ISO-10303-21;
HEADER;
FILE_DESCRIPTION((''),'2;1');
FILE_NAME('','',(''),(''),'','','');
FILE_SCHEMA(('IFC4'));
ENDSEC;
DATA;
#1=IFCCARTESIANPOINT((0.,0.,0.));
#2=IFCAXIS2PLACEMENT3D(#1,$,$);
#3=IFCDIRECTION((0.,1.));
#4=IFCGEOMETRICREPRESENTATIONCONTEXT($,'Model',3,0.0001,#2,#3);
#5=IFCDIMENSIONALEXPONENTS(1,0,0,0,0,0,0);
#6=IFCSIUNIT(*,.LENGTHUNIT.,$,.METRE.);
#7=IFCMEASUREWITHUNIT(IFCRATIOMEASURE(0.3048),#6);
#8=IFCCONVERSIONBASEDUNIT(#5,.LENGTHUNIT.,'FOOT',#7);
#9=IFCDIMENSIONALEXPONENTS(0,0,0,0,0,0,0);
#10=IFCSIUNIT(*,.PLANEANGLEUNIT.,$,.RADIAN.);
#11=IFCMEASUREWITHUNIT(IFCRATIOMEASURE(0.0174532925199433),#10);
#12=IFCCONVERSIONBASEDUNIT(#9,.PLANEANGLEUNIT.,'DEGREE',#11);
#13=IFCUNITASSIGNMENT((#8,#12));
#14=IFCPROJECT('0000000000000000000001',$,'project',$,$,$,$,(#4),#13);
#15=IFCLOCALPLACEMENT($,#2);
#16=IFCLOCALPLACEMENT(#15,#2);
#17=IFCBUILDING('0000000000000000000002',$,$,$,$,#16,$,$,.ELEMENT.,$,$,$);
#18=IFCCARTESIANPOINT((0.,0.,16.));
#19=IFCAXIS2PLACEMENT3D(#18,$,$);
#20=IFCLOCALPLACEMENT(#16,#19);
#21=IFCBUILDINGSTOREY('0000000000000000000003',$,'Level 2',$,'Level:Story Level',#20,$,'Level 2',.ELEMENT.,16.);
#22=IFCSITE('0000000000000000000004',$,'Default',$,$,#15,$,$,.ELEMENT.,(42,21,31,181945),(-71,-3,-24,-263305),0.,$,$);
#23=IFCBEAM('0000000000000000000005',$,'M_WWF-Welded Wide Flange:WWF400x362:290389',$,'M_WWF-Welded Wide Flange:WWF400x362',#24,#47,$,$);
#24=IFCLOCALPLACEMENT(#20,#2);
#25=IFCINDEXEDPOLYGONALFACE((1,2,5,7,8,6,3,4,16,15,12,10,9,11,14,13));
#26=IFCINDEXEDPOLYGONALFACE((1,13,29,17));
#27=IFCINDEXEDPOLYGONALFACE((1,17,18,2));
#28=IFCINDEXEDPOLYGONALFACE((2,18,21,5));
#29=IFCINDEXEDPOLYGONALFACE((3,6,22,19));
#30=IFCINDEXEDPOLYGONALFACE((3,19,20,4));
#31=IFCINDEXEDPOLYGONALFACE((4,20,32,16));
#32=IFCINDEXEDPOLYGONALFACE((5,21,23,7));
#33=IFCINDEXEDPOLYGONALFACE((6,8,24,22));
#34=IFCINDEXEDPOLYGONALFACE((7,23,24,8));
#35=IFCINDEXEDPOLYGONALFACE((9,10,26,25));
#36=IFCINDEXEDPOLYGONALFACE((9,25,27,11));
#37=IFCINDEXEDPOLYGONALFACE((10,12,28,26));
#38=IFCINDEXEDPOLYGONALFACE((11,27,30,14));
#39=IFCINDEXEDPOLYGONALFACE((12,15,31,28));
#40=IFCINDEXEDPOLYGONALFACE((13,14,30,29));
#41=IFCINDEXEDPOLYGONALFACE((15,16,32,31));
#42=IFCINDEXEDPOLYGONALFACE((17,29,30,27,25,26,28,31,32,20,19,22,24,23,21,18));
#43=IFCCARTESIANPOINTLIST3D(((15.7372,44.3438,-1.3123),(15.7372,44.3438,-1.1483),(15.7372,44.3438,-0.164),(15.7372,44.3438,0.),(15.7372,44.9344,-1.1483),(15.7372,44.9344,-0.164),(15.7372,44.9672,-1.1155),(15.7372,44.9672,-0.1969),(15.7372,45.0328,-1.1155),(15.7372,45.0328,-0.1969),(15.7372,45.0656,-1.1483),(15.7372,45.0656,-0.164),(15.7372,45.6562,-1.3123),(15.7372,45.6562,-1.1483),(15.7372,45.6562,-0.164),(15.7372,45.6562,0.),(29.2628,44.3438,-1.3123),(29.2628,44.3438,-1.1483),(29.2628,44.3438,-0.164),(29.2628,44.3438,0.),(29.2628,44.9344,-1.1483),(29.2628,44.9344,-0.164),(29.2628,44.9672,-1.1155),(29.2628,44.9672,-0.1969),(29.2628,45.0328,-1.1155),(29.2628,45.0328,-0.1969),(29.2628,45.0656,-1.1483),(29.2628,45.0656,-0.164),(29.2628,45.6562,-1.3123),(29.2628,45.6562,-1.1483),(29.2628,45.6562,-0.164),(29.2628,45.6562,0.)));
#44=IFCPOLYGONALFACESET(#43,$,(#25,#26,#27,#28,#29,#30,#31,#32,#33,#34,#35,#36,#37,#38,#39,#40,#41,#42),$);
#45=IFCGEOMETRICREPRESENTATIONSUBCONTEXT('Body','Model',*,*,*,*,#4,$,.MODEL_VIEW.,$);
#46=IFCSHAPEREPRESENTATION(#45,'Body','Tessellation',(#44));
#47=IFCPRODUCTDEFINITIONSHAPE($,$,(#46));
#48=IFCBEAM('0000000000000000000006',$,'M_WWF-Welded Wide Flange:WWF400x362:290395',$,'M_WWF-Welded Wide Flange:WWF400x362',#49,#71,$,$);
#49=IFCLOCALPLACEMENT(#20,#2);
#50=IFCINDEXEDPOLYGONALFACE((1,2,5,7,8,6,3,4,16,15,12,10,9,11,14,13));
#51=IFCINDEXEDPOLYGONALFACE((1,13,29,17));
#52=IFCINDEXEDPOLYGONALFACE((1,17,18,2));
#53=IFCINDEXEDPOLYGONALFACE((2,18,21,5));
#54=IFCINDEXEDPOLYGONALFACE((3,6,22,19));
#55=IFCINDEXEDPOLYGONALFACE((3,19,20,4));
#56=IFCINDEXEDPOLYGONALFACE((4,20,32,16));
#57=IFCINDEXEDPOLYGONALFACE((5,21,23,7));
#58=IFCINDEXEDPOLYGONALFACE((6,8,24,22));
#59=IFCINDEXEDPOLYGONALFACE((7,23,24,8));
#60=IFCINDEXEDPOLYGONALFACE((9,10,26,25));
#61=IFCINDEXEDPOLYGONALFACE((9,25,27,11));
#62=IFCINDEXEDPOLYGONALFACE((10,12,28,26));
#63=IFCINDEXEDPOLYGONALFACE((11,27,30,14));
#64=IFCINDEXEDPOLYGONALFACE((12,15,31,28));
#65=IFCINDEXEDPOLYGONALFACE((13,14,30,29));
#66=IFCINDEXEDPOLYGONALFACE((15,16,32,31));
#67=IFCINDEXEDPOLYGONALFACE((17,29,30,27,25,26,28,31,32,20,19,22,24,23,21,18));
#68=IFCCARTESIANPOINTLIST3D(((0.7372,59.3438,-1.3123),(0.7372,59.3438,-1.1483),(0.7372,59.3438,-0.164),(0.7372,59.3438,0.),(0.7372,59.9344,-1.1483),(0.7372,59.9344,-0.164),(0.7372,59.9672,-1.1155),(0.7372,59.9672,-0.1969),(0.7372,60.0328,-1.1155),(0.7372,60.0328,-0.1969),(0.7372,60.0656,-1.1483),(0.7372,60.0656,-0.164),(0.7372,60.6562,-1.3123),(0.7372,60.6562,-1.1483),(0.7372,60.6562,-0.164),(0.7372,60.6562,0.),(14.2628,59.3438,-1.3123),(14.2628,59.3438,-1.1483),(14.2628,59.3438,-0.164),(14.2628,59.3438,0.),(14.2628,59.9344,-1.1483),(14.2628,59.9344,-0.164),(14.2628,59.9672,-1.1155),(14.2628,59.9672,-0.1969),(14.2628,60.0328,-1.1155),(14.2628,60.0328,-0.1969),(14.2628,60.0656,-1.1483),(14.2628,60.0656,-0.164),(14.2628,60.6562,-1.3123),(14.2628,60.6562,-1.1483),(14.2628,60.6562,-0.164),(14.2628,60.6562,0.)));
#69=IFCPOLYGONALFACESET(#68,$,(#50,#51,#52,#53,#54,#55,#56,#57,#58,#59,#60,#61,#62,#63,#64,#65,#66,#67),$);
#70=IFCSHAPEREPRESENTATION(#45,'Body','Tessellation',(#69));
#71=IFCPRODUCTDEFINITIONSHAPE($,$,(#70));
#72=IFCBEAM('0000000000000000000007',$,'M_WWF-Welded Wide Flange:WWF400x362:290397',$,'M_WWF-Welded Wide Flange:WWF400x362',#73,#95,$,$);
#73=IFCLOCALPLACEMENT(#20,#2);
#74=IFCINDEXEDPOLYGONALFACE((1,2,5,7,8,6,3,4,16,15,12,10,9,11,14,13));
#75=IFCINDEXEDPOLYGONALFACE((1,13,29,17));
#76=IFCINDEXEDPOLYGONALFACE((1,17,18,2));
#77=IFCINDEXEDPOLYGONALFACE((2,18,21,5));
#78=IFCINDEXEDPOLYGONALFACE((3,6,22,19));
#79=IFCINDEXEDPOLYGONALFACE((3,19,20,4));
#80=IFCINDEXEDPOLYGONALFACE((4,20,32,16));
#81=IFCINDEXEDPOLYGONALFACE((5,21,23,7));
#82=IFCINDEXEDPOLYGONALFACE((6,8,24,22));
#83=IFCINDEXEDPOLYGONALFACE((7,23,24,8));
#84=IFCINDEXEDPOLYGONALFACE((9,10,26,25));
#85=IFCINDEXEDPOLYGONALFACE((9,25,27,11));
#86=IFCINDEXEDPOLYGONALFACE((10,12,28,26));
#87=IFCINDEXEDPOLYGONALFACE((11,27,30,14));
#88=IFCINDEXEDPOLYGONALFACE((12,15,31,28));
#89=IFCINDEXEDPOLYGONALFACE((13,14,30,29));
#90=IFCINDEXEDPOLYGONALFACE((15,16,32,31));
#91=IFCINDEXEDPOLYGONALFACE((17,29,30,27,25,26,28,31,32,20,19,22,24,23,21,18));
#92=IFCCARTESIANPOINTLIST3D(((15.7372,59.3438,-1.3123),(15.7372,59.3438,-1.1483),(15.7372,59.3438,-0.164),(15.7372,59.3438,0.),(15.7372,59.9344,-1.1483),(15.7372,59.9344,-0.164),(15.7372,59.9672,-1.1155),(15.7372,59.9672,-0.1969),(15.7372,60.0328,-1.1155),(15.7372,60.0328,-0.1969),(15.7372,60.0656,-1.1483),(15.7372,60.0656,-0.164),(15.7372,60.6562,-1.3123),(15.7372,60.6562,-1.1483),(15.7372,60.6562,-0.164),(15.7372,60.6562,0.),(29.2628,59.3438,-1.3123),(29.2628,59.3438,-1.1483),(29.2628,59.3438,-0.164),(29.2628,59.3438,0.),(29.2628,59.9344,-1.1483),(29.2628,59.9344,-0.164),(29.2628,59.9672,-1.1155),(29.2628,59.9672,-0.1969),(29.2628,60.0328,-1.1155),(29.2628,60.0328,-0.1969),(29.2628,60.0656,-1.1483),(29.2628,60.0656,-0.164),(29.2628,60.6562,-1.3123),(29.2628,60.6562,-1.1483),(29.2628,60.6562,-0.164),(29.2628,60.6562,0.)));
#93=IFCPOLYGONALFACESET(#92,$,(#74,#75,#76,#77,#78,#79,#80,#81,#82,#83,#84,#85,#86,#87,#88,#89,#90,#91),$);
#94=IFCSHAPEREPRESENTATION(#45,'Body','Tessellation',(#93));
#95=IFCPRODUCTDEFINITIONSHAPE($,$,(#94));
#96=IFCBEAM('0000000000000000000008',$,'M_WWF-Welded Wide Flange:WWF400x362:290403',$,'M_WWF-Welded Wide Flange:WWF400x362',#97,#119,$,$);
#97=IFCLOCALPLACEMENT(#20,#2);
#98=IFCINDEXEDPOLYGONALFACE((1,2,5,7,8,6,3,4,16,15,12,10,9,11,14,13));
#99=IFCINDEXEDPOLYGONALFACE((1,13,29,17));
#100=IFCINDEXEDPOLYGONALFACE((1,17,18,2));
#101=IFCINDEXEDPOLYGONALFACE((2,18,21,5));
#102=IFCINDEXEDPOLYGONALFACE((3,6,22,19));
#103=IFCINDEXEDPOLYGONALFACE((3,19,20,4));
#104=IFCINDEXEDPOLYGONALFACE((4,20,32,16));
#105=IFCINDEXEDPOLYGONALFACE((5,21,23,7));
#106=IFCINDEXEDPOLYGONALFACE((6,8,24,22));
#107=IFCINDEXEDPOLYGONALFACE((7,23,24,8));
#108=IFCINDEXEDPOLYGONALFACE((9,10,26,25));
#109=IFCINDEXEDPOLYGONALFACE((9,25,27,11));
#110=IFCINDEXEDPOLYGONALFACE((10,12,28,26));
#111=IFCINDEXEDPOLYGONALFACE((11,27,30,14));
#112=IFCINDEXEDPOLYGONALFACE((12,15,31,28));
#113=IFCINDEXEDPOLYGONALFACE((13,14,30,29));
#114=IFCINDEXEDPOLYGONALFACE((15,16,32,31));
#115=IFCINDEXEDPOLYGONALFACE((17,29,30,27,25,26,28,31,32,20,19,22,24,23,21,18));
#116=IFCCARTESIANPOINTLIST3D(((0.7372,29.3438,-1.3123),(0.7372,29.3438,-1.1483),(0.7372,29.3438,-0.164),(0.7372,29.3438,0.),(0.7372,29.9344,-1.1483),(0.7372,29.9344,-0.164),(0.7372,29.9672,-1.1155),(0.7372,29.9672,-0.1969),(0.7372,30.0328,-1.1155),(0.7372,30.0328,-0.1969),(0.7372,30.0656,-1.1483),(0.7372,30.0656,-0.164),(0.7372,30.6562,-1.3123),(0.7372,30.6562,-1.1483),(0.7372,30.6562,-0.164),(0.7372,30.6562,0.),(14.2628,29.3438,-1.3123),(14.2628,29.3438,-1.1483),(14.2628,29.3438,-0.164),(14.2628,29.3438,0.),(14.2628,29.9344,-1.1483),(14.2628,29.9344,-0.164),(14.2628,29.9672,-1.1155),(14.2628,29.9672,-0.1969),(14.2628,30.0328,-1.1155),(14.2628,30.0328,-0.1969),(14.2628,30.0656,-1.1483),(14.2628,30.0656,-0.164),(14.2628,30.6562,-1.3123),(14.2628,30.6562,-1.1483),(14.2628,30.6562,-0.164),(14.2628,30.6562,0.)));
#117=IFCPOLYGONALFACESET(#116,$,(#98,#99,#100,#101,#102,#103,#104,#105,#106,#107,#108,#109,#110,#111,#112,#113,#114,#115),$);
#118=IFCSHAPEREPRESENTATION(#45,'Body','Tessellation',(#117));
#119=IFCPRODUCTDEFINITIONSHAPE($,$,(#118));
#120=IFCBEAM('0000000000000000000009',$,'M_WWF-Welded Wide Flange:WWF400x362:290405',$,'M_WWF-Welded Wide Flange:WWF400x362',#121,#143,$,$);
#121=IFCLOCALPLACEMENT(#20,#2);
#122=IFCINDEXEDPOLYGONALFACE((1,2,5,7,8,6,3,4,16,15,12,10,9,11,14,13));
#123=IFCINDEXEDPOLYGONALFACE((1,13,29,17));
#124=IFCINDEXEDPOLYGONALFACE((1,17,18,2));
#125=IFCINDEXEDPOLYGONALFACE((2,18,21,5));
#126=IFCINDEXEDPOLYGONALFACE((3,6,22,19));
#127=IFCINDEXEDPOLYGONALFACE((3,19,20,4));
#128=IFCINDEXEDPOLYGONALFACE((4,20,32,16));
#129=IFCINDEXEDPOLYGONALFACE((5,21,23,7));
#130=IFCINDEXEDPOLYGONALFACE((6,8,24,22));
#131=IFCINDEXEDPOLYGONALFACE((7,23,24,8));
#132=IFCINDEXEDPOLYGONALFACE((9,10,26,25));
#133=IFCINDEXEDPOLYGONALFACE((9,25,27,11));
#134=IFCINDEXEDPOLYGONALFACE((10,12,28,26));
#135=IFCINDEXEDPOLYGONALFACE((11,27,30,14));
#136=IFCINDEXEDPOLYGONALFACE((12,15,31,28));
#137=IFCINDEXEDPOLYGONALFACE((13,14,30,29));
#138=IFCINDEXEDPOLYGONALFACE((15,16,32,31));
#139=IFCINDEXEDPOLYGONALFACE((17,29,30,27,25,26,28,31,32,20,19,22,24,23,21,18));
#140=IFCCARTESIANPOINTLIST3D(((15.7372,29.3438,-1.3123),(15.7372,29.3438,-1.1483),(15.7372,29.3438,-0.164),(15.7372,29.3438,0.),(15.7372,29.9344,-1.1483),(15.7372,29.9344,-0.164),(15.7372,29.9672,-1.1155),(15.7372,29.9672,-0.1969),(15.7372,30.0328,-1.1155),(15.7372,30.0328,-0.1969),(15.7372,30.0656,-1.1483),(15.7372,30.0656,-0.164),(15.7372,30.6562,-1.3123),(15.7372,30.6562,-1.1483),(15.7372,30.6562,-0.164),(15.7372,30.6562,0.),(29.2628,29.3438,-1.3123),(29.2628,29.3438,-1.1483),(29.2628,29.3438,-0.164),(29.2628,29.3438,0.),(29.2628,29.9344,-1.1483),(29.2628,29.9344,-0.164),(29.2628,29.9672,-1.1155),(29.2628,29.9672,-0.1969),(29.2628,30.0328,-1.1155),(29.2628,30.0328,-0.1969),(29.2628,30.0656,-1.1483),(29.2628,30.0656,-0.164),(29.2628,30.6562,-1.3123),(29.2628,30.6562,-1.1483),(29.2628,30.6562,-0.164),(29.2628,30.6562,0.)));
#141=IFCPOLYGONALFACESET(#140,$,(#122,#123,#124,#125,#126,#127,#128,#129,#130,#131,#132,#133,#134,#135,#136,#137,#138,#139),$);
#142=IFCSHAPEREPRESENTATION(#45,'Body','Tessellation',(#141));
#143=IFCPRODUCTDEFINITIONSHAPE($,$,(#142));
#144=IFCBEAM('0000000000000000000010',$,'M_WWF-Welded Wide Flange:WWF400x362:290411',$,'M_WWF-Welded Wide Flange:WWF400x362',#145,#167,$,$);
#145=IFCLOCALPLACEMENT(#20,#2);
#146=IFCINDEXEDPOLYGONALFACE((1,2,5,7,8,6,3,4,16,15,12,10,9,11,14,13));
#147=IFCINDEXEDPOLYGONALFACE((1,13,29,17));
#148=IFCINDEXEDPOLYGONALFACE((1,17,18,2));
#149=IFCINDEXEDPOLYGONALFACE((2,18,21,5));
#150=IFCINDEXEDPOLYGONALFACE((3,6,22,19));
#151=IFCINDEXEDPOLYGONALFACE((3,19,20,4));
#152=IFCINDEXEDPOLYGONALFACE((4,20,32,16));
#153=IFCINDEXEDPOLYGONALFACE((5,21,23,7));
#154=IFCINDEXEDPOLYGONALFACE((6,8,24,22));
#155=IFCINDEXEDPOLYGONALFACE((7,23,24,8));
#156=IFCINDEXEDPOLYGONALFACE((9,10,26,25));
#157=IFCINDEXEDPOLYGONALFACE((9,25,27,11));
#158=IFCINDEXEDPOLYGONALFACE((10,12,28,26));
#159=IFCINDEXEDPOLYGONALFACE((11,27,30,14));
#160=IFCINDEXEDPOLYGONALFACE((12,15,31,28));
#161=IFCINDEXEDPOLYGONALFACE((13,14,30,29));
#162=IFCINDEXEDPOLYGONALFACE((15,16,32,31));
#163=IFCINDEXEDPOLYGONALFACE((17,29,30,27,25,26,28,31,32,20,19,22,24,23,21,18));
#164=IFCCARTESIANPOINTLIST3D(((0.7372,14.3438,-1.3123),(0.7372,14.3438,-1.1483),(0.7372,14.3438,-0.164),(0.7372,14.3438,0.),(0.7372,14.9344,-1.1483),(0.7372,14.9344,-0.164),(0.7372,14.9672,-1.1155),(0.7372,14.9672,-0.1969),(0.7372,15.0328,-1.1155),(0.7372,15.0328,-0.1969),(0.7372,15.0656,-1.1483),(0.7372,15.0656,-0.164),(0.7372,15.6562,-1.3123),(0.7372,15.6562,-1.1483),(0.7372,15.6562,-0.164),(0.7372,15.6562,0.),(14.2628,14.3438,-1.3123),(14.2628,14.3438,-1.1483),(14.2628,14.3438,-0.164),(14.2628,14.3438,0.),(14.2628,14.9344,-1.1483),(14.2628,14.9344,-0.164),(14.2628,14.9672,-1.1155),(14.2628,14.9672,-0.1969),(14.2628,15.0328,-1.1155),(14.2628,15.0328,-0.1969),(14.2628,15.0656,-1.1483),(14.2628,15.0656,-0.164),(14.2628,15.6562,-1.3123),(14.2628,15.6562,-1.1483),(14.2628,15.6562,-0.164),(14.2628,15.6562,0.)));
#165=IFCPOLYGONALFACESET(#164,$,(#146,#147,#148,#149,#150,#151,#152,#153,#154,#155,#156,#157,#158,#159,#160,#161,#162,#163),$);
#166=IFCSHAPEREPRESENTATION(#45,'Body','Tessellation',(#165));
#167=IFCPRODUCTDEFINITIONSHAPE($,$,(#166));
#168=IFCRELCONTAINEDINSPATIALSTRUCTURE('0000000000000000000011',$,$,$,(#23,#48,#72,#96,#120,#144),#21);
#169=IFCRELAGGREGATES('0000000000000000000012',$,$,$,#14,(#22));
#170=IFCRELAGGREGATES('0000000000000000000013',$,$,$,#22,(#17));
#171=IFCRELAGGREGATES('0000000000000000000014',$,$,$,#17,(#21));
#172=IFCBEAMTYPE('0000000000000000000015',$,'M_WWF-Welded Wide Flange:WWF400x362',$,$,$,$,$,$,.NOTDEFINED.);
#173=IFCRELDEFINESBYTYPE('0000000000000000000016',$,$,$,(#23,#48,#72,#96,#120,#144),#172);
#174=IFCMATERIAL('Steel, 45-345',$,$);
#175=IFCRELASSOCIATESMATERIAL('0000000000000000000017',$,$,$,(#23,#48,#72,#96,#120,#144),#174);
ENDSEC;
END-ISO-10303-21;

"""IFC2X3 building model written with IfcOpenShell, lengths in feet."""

from ifc_helpers import new_model, entity, si_unit, converted_unit, direction, frame, origin, place, context, subcontext, project, spatial, polyline, outline, extrude, material, type_object, element, save


model = new_model("IFC2X3")

# Units and contexts
model_context = context("Model", 3, precision=0.0001, world=origin(), true_north=direction((0.0, 1.0)))
body_context = subcontext(model_context, "Body", "Model", "MODEL_VIEW")
ifc_project = project(units=[converted_unit("LENGTHUNIT", "FOOT", entity("IfcRatioMeasure", 0.3048), si_unit("LENGTHUNIT", "METRE"), dimensions=[1, 0, 0, 0, 0, 0, 0]), converted_unit("PLANEANGLEUNIT", "DEGREE", entity("IfcRatioMeasure", 0.0174532925199433), si_unit("PLANEANGLEUNIT", "RADIAN"), dimensions=[0, 0, 0, 0, 0, 0, 0])], contexts=[model_context])

# Site, building, storey
site_placement = place(None, origin())
site = spatial("IfcSite", under=ifc_project, at=site_placement, Name="Default", CompositionType="ELEMENT", RefLatitude=(42, 21, 31, 181945), RefLongitude=(-71, -3, -24, -263305), RefElevation=0.0)
building_placement = place(site_placement, origin())
building = spatial("IfcBuilding", under=site, at=building_placement, CompositionType="ELEMENT")
storey_placement = place(building_placement, frame((0.0, 0.0, 16.0)))
storey = spatial("IfcBuildingStorey", under=building, at=storey_placement, Name="Level 2", ObjectType="Level:Story Level", LongName="Level 2", CompositionType="ELEMENT", Elevation=16.0)

# Shared definitions
ifc_material = material(Name="Steel, 45-345")

# Beams
beam_type = type_object("IfcBeamType", Name="M_WWF-Welded Wide Flange:WWF400x362", PredefinedType="NOTDEFINED")
beam_1_placement = place(storey_placement, frame((15.0, 45.0, 0.0)))
element("IfcBeam", 1, at=beam_1_placement, inside=storey, type_object=beam_type, material=ifc_material, Name="M_WWF-Welded Wide Flange:WWF400x362:290389", ObjectType="M_WWF-Welded Wide Flange:WWF400x362", context=body_context, shape_type="SweptSolid", body=[
    extrude(outline(polyline([(-0.6562, -0.6562), (-0.4921, -0.6562), (-0.4921, -0.0656), (-0.4593, -0.0328), (0.4593, -0.0328), (0.4921, -0.0656), (0.4921, -0.6562), (0.6562, -0.6562), (0.6562, 0.6562), (0.4921, 0.6562), (0.4921, 0.0656), (0.4593, 0.0328), (-0.4593, 0.0328), (-0.4921, 0.0656), (-0.4921, 0.6562), (-0.6562, 0.6562), (-0.6562, -0.6562)])), frame((0.7372, 0.0, -0.6562), z_axis=(1.0, 0.0, 0.0), x_axis=(0.0, 0.0, -1.0)), (0.0, 0.0, 1.0), 13.5256),
])
beam_2_placement = place(storey_placement, frame((0.0, 60.0, 0.0)))
element("IfcBeam", 2, at=beam_2_placement, inside=storey, type_object=beam_type, material=ifc_material, Name="M_WWF-Welded Wide Flange:WWF400x362:290395", ObjectType="M_WWF-Welded Wide Flange:WWF400x362", context=body_context, shape_type="SweptSolid", body=[
    extrude(outline(polyline([(-0.6562, -0.6562), (-0.4921, -0.6562), (-0.4921, -0.0656), (-0.4593, -0.0328), (0.4593, -0.0328), (0.4921, -0.0656), (0.4921, -0.6562), (0.6562, -0.6562), (0.6562, 0.6562), (0.4921, 0.6562), (0.4921, 0.0656), (0.4593, 0.0328), (-0.4593, 0.0328), (-0.4921, 0.0656), (-0.4921, 0.6562), (-0.6562, 0.6562), (-0.6562, -0.6562)])), frame((0.7372, 0.0, -0.6562), z_axis=(1.0, 0.0, 0.0), x_axis=(0.0, 0.0, -1.0)), (0.0, 0.0, 1.0), 13.5256),
])
beam_3_placement = place(storey_placement, frame((15.0, 60.0, 0.0)))
element("IfcBeam", 3, at=beam_3_placement, inside=storey, type_object=beam_type, material=ifc_material, Name="M_WWF-Welded Wide Flange:WWF400x362:290397", ObjectType="M_WWF-Welded Wide Flange:WWF400x362", context=body_context, shape_type="SweptSolid", body=[
    extrude(outline(polyline([(-0.6562, -0.6562), (-0.4921, -0.6562), (-0.4921, -0.0656), (-0.4593, -0.0328), (0.4593, -0.0328), (0.4921, -0.0656), (0.4921, -0.6562), (0.6562, -0.6562), (0.6562, 0.6562), (0.4921, 0.6562), (0.4921, 0.0656), (0.4593, 0.0328), (-0.4593, 0.0328), (-0.4921, 0.0656), (-0.4921, 0.6562), (-0.6562, 0.6562), (-0.6562, -0.6562)])), frame((0.7372, 0.0, -0.6562), z_axis=(1.0, 0.0, 0.0), x_axis=(0.0, 0.0, -1.0)), (0.0, 0.0, 1.0), 13.5256),
])
beam_4_placement = place(storey_placement, frame((0.0, 30.0, 0.0)))
element("IfcBeam", 4, at=beam_4_placement, inside=storey, type_object=beam_type, material=ifc_material, Name="M_WWF-Welded Wide Flange:WWF400x362:290403", ObjectType="M_WWF-Welded Wide Flange:WWF400x362", context=body_context, shape_type="SweptSolid", body=[
    extrude(outline(polyline([(-0.6562, -0.6562), (-0.4921, -0.6562), (-0.4921, -0.0656), (-0.4593, -0.0328), (0.4593, -0.0328), (0.4921, -0.0656), (0.4921, -0.6562), (0.6562, -0.6562), (0.6562, 0.6562), (0.4921, 0.6562), (0.4921, 0.0656), (0.4593, 0.0328), (-0.4593, 0.0328), (-0.4921, 0.0656), (-0.4921, 0.6562), (-0.6562, 0.6562), (-0.6562, -0.6562)])), frame((0.7372, 0.0, -0.6562), z_axis=(1.0, 0.0, 0.0), x_axis=(0.0, 0.0, -1.0)), (0.0, 0.0, 1.0), 13.5256),
])
beam_5_placement = place(storey_placement, frame((15.0, 30.0, 0.0)))
element("IfcBeam", 5, at=beam_5_placement, inside=storey, type_object=beam_type, material=ifc_material, Name="M_WWF-Welded Wide Flange:WWF400x362:290405", ObjectType="M_WWF-Welded Wide Flange:WWF400x362", context=body_context, shape_type="SweptSolid", body=[
    extrude(outline(polyline([(-0.6562, -0.6562), (-0.4921, -0.6562), (-0.4921, -0.0656), (-0.4593, -0.0328), (0.4593, -0.0328), (0.4921, -0.0656), (0.4921, -0.6562), (0.6562, -0.6562), (0.6562, 0.6562), (0.4921, 0.6562), (0.4921, 0.0656), (0.4593, 0.0328), (-0.4593, 0.0328), (-0.4921, 0.0656), (-0.4921, 0.6562), (-0.6562, 0.6562), (-0.6562, -0.6562)])), frame((0.7372, 0.0, -0.6562), z_axis=(1.0, 0.0, 0.0), x_axis=(0.0, 0.0, -1.0)), (0.0, 0.0, 1.0), 13.5256),
])
beam_6_placement = place(storey_placement, frame((0.0, 15.0, 0.0)))
element("IfcBeam", 6, at=beam_6_placement, inside=storey, type_object=beam_type, material=ifc_material, Name="M_WWF-Welded Wide Flange:WWF400x362:290411", ObjectType="M_WWF-Welded Wide Flange:WWF400x362", context=body_context, shape_type="SweptSolid", body=[
    extrude(outline(polyline([(-0.6562, -0.6562), (-0.4921, -0.6562), (-0.4921, -0.0656), (-0.4593, -0.0328), (0.4593, -0.0328), (0.4921, -0.0656), (0.4921, -0.6562), (0.6562, -0.6562), (0.6562, 0.6562), (0.4921, 0.6562), (0.4921, 0.0656), (0.4593, 0.0328), (-0.4593, 0.0328), (-0.4921, 0.0656), (-0.4921, 0.6562), (-0.6562, 0.6562), (-0.6562, -0.6562)])), frame((0.7372, 0.0, -0.6562), z_axis=(1.0, 0.0, 0.0), x_axis=(0.0, 0.0, -1.0)), (0.0, 0.0, 1.0), 13.5256),
])

save(model, "model.ifc")
